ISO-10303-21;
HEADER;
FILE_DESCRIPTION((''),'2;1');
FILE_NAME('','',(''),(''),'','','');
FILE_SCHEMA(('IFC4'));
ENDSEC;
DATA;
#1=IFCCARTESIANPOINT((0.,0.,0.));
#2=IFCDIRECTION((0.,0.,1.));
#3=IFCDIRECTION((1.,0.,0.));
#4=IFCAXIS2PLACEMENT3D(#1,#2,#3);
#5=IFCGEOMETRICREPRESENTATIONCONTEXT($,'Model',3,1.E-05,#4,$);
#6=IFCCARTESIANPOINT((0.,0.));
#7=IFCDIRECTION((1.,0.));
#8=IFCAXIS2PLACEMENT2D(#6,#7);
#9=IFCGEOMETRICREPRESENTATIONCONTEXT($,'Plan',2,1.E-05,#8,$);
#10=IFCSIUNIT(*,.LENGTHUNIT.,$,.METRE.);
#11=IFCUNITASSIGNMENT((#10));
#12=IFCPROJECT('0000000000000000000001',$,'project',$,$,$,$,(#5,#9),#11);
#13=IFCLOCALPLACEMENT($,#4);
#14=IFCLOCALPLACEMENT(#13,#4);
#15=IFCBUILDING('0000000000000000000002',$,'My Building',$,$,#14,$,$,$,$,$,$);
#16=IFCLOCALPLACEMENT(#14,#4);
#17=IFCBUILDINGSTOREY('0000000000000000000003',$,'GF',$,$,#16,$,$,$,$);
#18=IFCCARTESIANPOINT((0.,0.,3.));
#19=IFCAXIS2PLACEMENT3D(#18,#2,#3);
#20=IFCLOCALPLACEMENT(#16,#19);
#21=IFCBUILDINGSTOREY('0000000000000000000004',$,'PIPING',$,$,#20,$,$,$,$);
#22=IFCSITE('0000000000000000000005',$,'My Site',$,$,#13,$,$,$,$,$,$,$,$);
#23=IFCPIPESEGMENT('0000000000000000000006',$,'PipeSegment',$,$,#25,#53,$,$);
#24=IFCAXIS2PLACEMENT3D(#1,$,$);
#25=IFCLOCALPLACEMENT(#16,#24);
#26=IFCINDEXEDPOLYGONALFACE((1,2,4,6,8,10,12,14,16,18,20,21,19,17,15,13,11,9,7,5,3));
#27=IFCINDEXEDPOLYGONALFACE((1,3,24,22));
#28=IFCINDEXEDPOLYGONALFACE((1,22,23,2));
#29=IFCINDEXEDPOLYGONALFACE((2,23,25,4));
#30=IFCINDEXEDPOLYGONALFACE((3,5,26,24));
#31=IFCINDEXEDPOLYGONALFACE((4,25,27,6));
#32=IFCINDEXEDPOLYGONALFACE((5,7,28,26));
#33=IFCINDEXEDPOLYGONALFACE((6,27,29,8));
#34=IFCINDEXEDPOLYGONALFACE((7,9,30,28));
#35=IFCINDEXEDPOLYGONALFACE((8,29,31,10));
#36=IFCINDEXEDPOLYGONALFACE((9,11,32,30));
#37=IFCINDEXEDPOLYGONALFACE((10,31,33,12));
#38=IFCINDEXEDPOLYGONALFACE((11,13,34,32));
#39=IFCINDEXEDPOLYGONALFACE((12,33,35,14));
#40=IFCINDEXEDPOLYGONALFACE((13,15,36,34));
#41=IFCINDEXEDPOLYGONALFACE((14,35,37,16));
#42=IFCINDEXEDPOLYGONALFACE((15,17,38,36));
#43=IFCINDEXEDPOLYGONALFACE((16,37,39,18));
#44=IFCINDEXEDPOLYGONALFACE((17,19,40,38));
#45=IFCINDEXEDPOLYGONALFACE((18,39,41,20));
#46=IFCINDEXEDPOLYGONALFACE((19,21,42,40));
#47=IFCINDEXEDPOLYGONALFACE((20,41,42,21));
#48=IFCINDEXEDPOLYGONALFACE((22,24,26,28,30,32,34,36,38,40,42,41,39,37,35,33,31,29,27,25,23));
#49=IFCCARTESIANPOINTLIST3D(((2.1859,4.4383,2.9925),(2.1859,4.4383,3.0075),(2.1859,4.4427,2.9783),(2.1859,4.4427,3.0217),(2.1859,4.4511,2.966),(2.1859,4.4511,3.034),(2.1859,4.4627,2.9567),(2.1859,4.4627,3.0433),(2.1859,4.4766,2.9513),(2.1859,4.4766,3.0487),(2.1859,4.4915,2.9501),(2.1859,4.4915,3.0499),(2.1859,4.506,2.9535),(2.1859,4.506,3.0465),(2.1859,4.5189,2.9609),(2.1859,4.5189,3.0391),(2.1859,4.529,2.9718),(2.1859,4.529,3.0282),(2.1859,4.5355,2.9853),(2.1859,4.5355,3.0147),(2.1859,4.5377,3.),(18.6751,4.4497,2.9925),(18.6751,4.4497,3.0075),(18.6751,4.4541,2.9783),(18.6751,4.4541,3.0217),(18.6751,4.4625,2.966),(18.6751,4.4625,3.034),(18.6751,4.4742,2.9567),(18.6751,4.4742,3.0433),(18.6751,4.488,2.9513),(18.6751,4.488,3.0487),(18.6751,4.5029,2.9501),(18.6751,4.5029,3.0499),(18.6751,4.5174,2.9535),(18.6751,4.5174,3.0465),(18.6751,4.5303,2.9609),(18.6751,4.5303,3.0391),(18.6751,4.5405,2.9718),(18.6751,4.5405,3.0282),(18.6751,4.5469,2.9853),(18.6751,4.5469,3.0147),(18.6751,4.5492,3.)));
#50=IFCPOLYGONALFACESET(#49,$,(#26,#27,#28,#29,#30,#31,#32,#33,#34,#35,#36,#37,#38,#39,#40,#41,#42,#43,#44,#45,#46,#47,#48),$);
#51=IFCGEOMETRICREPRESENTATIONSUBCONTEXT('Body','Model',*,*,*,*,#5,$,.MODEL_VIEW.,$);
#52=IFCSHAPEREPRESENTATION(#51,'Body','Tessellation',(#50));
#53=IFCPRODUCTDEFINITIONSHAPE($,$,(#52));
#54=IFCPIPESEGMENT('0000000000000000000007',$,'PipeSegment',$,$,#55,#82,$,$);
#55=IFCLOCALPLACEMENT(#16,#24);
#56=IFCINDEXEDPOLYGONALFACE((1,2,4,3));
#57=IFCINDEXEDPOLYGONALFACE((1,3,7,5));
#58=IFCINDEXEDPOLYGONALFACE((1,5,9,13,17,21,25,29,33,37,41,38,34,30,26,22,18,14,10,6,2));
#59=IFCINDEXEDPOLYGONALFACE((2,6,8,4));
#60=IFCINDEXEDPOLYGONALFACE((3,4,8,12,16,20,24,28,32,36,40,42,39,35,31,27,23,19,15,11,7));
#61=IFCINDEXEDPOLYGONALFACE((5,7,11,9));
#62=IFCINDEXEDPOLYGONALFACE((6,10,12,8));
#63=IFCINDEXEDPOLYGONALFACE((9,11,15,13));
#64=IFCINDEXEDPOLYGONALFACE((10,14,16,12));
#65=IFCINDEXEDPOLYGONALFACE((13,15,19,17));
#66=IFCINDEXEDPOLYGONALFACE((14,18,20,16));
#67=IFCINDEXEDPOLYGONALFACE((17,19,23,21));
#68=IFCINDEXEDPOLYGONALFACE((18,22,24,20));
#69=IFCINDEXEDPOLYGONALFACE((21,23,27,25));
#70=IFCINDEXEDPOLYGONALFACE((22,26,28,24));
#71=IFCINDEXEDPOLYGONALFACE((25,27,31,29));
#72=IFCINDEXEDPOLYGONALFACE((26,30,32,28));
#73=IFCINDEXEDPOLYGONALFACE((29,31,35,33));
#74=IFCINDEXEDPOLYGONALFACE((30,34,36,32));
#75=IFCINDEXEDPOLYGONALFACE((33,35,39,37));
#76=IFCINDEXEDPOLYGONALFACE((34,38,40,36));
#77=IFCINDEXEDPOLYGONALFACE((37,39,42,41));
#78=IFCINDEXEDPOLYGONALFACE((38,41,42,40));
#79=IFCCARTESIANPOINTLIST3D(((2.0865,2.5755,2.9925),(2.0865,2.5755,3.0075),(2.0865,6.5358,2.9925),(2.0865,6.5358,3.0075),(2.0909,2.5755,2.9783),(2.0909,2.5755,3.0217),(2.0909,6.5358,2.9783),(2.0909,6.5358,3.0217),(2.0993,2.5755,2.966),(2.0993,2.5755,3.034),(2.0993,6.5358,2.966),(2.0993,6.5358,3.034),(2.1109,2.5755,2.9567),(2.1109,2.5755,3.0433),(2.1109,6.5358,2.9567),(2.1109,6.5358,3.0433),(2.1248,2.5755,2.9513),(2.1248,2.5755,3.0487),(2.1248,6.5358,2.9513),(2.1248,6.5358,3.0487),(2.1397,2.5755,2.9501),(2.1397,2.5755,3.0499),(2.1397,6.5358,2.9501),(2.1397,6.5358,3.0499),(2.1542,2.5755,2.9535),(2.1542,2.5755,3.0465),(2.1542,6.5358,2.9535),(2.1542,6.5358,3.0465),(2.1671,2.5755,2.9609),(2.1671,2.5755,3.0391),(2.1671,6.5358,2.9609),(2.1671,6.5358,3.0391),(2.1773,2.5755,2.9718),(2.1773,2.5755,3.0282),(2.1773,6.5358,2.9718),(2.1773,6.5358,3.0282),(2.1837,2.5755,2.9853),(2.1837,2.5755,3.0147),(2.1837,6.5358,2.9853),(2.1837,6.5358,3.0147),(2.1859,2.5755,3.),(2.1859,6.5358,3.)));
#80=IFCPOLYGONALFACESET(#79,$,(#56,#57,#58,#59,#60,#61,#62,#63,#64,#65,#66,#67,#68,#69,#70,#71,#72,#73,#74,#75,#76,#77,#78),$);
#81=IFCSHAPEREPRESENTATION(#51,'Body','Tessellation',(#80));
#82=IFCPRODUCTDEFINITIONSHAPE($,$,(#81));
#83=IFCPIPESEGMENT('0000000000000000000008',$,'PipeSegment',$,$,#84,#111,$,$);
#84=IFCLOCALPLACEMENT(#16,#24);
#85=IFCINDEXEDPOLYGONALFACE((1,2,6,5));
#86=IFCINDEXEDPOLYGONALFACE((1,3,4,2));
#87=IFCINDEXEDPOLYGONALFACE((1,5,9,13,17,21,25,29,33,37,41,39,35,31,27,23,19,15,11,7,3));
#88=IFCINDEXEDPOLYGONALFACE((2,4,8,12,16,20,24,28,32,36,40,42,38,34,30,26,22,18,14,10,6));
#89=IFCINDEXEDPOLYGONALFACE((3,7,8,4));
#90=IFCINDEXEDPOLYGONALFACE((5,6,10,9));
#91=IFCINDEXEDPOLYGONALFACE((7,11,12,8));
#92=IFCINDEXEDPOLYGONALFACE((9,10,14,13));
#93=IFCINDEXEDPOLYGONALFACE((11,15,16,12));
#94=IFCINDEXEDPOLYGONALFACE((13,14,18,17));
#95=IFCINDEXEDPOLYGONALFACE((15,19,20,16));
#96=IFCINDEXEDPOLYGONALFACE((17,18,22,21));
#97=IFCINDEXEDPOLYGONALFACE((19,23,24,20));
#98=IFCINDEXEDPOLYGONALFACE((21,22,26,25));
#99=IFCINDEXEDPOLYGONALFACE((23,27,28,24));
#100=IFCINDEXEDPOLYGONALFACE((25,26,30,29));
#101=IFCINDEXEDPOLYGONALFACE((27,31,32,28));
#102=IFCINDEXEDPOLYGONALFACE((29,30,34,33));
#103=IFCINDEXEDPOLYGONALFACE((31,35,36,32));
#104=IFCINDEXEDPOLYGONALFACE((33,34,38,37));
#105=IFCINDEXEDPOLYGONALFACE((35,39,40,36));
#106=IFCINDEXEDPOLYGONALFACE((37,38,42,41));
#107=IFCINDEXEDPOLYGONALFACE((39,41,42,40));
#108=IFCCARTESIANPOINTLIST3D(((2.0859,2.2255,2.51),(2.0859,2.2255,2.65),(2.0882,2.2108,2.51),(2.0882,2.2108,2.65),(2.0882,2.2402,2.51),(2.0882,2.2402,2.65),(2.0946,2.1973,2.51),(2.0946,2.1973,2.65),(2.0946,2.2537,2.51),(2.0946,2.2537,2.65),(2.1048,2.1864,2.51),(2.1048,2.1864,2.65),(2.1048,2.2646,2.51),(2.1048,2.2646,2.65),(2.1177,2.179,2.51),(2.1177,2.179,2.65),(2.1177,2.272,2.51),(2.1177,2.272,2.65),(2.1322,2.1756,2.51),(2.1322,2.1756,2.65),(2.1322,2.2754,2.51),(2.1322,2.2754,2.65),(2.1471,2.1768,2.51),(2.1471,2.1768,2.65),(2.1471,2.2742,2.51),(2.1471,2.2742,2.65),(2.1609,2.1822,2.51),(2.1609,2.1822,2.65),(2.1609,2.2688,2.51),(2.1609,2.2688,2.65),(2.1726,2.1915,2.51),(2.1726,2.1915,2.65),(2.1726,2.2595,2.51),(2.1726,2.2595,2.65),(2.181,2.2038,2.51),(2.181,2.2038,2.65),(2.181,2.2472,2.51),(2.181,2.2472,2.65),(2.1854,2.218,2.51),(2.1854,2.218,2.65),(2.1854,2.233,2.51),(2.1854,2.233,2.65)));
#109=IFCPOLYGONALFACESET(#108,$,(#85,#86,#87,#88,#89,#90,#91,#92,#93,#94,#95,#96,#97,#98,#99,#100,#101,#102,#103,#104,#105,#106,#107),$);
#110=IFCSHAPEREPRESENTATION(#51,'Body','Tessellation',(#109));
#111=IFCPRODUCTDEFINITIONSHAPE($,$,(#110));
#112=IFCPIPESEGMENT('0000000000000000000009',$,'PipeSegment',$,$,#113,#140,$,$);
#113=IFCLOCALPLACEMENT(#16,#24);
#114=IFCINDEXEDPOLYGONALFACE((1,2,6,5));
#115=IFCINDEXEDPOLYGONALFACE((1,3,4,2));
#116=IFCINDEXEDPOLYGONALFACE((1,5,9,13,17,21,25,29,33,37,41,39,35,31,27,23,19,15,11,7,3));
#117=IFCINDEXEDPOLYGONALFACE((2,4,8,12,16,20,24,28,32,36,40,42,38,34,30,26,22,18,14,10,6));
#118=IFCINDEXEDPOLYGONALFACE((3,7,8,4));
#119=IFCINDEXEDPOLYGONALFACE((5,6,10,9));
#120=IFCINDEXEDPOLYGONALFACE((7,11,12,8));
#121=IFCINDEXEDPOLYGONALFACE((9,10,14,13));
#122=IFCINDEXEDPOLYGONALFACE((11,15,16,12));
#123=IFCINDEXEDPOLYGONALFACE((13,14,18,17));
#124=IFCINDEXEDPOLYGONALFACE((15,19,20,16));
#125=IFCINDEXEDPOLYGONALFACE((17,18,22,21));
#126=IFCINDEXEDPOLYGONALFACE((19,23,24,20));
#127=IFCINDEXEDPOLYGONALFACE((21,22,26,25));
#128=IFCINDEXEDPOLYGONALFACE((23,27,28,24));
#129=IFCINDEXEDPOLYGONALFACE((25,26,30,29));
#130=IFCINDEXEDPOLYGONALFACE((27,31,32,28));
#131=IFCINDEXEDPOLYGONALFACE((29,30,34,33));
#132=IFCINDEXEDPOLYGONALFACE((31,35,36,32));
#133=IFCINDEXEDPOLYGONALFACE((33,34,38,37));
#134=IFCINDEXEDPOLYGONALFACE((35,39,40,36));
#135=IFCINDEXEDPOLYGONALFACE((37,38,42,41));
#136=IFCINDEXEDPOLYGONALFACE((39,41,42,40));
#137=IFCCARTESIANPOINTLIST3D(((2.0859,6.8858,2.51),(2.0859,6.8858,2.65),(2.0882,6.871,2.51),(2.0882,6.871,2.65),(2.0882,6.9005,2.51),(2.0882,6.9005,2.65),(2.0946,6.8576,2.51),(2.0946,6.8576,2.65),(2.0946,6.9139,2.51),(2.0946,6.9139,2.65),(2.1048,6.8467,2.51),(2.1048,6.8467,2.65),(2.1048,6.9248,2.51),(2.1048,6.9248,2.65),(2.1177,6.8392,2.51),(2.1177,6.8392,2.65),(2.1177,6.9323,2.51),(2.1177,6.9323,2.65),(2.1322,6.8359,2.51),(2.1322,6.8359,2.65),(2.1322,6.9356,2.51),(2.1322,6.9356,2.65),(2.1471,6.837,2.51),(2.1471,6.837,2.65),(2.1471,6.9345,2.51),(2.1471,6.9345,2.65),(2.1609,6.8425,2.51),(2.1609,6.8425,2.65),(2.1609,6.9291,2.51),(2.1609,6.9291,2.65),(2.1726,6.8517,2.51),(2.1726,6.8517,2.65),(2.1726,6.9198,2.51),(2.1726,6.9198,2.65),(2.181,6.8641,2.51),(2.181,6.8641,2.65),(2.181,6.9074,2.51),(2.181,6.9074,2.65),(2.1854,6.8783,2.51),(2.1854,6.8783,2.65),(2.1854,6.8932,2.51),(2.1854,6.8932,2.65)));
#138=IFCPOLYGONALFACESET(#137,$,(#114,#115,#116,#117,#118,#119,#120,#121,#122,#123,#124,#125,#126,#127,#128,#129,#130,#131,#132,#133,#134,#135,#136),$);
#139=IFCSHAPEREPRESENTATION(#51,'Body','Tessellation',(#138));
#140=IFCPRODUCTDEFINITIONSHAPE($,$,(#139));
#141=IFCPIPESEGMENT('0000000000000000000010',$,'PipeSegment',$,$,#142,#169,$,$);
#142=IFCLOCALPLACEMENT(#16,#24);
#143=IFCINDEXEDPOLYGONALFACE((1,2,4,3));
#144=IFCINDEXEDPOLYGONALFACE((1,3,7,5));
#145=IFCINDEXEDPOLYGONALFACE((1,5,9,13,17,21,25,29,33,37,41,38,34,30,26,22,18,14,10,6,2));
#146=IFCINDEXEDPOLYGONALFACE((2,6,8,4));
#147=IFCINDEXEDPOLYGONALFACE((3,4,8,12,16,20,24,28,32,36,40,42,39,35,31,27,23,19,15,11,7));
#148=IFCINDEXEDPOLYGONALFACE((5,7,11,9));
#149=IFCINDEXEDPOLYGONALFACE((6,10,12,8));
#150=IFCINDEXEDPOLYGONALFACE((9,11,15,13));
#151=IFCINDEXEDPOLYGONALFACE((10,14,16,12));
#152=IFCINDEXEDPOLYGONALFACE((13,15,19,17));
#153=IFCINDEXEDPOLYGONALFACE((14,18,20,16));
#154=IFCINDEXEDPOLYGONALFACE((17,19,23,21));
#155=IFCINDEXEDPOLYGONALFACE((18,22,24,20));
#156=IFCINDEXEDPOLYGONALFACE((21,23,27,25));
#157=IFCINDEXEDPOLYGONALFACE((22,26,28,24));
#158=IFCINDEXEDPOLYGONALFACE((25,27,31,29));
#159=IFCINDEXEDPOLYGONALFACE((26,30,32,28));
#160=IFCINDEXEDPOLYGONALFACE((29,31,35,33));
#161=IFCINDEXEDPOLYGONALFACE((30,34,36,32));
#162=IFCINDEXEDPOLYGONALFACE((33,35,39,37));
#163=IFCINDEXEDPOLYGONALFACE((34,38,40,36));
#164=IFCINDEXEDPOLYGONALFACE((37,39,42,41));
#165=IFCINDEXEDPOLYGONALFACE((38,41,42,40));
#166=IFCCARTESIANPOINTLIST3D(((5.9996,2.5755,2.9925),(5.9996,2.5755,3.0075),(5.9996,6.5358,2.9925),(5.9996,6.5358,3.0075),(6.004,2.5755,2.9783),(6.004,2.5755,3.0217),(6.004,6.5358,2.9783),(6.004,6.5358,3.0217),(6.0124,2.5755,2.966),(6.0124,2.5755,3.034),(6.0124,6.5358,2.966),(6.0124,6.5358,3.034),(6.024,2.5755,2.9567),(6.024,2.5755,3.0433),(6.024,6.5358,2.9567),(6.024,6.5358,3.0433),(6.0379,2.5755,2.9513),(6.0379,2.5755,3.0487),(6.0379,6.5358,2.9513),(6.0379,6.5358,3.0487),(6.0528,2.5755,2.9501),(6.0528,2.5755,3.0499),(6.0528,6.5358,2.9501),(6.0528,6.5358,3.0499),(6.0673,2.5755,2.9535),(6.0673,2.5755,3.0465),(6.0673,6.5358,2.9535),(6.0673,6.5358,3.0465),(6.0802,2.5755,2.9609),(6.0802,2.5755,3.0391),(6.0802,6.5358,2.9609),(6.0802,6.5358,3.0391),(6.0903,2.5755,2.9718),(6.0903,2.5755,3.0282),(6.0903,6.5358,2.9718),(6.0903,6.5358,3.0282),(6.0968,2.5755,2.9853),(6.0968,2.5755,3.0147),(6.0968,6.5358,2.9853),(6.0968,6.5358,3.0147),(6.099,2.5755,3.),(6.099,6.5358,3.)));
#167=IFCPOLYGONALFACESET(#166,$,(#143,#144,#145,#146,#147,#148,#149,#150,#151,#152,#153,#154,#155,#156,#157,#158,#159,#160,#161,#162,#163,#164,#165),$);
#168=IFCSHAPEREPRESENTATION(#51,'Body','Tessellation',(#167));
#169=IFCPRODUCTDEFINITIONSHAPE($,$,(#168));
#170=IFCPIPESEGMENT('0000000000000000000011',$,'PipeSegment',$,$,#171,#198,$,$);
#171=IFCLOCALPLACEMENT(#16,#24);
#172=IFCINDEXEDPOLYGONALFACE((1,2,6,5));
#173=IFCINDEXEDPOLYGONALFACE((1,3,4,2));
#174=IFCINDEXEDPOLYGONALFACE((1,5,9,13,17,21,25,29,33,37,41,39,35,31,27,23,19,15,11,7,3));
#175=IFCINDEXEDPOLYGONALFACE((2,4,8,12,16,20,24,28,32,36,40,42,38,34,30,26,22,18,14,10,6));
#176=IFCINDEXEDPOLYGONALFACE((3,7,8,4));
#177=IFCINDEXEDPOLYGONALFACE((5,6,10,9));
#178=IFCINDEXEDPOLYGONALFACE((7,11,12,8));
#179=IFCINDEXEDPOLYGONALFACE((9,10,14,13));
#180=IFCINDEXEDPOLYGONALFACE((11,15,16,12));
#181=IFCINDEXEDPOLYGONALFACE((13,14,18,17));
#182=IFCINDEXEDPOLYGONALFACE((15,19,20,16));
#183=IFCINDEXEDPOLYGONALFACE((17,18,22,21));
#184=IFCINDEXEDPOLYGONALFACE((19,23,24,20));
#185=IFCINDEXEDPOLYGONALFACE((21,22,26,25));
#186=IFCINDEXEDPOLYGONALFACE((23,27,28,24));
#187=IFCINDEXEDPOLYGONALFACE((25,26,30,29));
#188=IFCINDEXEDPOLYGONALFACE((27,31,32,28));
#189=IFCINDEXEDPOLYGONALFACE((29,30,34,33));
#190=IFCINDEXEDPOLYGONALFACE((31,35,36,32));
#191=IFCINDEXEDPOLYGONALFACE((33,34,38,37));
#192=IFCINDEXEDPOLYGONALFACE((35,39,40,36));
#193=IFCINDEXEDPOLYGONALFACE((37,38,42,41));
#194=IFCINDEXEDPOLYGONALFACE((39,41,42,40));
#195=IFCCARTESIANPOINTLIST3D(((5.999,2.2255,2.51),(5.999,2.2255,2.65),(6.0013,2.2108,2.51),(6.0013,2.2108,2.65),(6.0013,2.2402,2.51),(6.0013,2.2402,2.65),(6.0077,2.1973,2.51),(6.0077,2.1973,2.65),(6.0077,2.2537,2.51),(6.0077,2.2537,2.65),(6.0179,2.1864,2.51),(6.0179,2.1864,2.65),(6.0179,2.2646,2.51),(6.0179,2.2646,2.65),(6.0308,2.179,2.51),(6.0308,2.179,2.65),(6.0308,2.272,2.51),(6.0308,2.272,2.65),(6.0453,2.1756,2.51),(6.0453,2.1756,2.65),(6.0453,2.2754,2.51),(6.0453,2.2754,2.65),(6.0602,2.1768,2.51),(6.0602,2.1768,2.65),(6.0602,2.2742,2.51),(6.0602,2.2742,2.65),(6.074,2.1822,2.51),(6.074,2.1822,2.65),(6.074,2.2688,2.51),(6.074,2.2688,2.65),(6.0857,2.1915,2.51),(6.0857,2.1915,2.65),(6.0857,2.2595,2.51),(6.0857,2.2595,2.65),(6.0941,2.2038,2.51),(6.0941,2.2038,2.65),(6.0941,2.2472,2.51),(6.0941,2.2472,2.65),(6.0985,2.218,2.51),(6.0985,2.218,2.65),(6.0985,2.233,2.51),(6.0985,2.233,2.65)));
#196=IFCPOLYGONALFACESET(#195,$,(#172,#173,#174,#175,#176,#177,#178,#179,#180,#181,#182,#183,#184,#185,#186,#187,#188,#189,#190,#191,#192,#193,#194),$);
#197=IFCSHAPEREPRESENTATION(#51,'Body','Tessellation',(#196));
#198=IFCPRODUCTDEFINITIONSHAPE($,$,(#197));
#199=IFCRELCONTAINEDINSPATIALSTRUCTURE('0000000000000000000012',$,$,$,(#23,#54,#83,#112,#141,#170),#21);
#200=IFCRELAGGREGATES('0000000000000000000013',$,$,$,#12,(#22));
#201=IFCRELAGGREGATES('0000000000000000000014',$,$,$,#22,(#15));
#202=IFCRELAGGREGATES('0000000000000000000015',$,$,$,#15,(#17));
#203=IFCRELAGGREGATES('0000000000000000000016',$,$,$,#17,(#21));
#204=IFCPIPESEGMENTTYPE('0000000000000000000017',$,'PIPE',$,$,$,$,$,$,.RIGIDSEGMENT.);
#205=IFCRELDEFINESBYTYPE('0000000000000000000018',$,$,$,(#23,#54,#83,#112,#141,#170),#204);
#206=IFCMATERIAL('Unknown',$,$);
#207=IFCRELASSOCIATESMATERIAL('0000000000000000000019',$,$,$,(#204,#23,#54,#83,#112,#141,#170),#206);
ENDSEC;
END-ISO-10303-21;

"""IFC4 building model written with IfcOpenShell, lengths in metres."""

from ifc_helpers import new_model, si_unit, frame, origin_with_axes, origin_2d_with_axis, place, context, subcontext, project, spatial, circle, extrude, material, material_profile, profile_set, profile_usage, type_object, element, save


model = new_model("IFC4")

# Units and contexts
model_context = context("Model", 3, precision=1e-05, world=origin_with_axes())
plan_context = context("Plan", 2, precision=1e-05, world=origin_2d_with_axis())
body_context = subcontext(model_context, "Body", "Model", "MODEL_VIEW")
ifc_project = project(units=[si_unit("LENGTHUNIT", "METRE")], contexts=[model_context, plan_context])

# Site, building, storeys
site_placement = place(None, origin_with_axes())
site = spatial("IfcSite", under=ifc_project, at=site_placement, Name="My Site")
building_placement = place(site_placement, origin_with_axes())
building = spatial("IfcBuilding", under=site, at=building_placement, Name="My Building")
storey_1_placement = place(building_placement, origin_with_axes())
storey_1 = spatial("IfcBuildingStorey", under=building, at=storey_1_placement, Name="GF")
storey_2_placement = place(storey_1_placement, frame((0.0, 0.0, 3.0), z_axis=(0.0, 0.0, 1.0), x_axis=(1.0, 0.0, 0.0)))
storey_2 = spatial("IfcBuildingStorey", under=storey_1, at=storey_2_placement, Name="PIPING")

# Pipe segments
ifc_material = material(Name="Unknown")
ifc_material_profile = material_profile(ifc_material, circle(Radius=0.05))
ifc_profile_set = profile_set([ifc_material_profile])
ifc_profile_usage_1 = profile_usage(ifc_profile_set, cardinal=5)
pipe_segment_type = type_object("IfcPipeSegmentType", Name="PIPE", PredefinedType="RIGIDSEGMENT", material=ifc_profile_set)
pipe_segment_1_placement = place(storey_2_placement, frame((2.1859, 4.4877, 0.0), z_axis=(1.0, 0.000693, 0.0), x_axis=(-0.000693, 1.0, 0.0)))
element("IfcPipeSegment", 1, at=pipe_segment_1_placement, inside=storey_2, type_object=pipe_segment_type, material=ifc_profile_usage_1, Name="PipeSegment", context=body_context, shape_type="SweptSolid", body=[
    extrude(circle(Radius=0.05), origin_with_axes(), (0.0, 0.0, 1.0), 16.4892),
])
ifc_profile_usage_2 = profile_usage(ifc_profile_set, cardinal=5)
pipe_segment_2_placement = place(storey_2_placement, frame((2.1359, 6.5358, 0.0), z_axis=(0.0, -1.0, 0.0), x_axis=(1.0, 0.0, 0.0)))
element("IfcPipeSegment", 2, at=pipe_segment_2_placement, inside=storey_2, type_object=pipe_segment_type, material=ifc_profile_usage_2, Name="PipeSegment", context=body_context, shape_type="SweptSolid", body=[
    extrude(circle(Radius=0.05), origin_with_axes(), (0.0, 0.0, 1.0), 3.9603),
])
ifc_profile_usage_3 = profile_usage(ifc_profile_set, cardinal=5)
pipe_segment_3_placement = place(storey_2_placement, frame((2.1359, 2.2255, -0.35), z_axis=(0.0, 0.0, -1.0), x_axis=(-1.0, 0.0, 0.0)))
element("IfcPipeSegment", 3, at=pipe_segment_3_placement, inside=storey_2, type_object=pipe_segment_type, material=ifc_profile_usage_3, Name="PipeSegment", context=body_context, shape_type="SweptSolid", body=[
    extrude(circle(Radius=0.05), origin_with_axes(), (0.0, 0.0, 1.0), 0.14),
])
ifc_profile_usage_4 = profile_usage(ifc_profile_set, cardinal=5)
pipe_segment_4_placement = place(storey_2_placement, frame((2.1359, 6.8858, -0.35), z_axis=(0.0, 0.0, -1.0), x_axis=(-1.0, 0.0, 0.0)))
element("IfcPipeSegment", 4, at=pipe_segment_4_placement, inside=storey_2, type_object=pipe_segment_type, material=ifc_profile_usage_4, Name="PipeSegment", context=body_context, shape_type="SweptSolid", body=[
    extrude(circle(Radius=0.05), origin_with_axes(), (0.0, 0.0, 1.0), 0.14),
])
ifc_profile_usage_5 = profile_usage(ifc_profile_set, cardinal=5)
pipe_segment_5_placement = place(storey_2_placement, frame((6.049, 6.5358, 0.0), z_axis=(0.0, -1.0, 0.0), x_axis=(1.0, 0.0, 0.0)))
element("IfcPipeSegment", 5, at=pipe_segment_5_placement, inside=storey_2, type_object=pipe_segment_type, material=ifc_profile_usage_5, Name="PipeSegment", context=body_context, shape_type="SweptSolid", body=[
    extrude(circle(Radius=0.05), origin_with_axes(), (0.0, 0.0, 1.0), 3.9603),
])
ifc_profile_usage_6 = profile_usage(ifc_profile_set, cardinal=5)
pipe_segment_6_placement = place(storey_2_placement, frame((6.049, 2.2255, -0.35), z_axis=(0.0, 0.0, -1.0), x_axis=(-1.0, 0.0, 0.0)))
element("IfcPipeSegment", 6, at=pipe_segment_6_placement, inside=storey_2, type_object=pipe_segment_type, material=ifc_profile_usage_6, Name="PipeSegment", context=body_context, shape_type="SweptSolid", body=[
    extrude(circle(Radius=0.05), origin_with_axes(), (0.0, 0.0, 1.0), 0.14),
])

save(model, "model.ifc")
